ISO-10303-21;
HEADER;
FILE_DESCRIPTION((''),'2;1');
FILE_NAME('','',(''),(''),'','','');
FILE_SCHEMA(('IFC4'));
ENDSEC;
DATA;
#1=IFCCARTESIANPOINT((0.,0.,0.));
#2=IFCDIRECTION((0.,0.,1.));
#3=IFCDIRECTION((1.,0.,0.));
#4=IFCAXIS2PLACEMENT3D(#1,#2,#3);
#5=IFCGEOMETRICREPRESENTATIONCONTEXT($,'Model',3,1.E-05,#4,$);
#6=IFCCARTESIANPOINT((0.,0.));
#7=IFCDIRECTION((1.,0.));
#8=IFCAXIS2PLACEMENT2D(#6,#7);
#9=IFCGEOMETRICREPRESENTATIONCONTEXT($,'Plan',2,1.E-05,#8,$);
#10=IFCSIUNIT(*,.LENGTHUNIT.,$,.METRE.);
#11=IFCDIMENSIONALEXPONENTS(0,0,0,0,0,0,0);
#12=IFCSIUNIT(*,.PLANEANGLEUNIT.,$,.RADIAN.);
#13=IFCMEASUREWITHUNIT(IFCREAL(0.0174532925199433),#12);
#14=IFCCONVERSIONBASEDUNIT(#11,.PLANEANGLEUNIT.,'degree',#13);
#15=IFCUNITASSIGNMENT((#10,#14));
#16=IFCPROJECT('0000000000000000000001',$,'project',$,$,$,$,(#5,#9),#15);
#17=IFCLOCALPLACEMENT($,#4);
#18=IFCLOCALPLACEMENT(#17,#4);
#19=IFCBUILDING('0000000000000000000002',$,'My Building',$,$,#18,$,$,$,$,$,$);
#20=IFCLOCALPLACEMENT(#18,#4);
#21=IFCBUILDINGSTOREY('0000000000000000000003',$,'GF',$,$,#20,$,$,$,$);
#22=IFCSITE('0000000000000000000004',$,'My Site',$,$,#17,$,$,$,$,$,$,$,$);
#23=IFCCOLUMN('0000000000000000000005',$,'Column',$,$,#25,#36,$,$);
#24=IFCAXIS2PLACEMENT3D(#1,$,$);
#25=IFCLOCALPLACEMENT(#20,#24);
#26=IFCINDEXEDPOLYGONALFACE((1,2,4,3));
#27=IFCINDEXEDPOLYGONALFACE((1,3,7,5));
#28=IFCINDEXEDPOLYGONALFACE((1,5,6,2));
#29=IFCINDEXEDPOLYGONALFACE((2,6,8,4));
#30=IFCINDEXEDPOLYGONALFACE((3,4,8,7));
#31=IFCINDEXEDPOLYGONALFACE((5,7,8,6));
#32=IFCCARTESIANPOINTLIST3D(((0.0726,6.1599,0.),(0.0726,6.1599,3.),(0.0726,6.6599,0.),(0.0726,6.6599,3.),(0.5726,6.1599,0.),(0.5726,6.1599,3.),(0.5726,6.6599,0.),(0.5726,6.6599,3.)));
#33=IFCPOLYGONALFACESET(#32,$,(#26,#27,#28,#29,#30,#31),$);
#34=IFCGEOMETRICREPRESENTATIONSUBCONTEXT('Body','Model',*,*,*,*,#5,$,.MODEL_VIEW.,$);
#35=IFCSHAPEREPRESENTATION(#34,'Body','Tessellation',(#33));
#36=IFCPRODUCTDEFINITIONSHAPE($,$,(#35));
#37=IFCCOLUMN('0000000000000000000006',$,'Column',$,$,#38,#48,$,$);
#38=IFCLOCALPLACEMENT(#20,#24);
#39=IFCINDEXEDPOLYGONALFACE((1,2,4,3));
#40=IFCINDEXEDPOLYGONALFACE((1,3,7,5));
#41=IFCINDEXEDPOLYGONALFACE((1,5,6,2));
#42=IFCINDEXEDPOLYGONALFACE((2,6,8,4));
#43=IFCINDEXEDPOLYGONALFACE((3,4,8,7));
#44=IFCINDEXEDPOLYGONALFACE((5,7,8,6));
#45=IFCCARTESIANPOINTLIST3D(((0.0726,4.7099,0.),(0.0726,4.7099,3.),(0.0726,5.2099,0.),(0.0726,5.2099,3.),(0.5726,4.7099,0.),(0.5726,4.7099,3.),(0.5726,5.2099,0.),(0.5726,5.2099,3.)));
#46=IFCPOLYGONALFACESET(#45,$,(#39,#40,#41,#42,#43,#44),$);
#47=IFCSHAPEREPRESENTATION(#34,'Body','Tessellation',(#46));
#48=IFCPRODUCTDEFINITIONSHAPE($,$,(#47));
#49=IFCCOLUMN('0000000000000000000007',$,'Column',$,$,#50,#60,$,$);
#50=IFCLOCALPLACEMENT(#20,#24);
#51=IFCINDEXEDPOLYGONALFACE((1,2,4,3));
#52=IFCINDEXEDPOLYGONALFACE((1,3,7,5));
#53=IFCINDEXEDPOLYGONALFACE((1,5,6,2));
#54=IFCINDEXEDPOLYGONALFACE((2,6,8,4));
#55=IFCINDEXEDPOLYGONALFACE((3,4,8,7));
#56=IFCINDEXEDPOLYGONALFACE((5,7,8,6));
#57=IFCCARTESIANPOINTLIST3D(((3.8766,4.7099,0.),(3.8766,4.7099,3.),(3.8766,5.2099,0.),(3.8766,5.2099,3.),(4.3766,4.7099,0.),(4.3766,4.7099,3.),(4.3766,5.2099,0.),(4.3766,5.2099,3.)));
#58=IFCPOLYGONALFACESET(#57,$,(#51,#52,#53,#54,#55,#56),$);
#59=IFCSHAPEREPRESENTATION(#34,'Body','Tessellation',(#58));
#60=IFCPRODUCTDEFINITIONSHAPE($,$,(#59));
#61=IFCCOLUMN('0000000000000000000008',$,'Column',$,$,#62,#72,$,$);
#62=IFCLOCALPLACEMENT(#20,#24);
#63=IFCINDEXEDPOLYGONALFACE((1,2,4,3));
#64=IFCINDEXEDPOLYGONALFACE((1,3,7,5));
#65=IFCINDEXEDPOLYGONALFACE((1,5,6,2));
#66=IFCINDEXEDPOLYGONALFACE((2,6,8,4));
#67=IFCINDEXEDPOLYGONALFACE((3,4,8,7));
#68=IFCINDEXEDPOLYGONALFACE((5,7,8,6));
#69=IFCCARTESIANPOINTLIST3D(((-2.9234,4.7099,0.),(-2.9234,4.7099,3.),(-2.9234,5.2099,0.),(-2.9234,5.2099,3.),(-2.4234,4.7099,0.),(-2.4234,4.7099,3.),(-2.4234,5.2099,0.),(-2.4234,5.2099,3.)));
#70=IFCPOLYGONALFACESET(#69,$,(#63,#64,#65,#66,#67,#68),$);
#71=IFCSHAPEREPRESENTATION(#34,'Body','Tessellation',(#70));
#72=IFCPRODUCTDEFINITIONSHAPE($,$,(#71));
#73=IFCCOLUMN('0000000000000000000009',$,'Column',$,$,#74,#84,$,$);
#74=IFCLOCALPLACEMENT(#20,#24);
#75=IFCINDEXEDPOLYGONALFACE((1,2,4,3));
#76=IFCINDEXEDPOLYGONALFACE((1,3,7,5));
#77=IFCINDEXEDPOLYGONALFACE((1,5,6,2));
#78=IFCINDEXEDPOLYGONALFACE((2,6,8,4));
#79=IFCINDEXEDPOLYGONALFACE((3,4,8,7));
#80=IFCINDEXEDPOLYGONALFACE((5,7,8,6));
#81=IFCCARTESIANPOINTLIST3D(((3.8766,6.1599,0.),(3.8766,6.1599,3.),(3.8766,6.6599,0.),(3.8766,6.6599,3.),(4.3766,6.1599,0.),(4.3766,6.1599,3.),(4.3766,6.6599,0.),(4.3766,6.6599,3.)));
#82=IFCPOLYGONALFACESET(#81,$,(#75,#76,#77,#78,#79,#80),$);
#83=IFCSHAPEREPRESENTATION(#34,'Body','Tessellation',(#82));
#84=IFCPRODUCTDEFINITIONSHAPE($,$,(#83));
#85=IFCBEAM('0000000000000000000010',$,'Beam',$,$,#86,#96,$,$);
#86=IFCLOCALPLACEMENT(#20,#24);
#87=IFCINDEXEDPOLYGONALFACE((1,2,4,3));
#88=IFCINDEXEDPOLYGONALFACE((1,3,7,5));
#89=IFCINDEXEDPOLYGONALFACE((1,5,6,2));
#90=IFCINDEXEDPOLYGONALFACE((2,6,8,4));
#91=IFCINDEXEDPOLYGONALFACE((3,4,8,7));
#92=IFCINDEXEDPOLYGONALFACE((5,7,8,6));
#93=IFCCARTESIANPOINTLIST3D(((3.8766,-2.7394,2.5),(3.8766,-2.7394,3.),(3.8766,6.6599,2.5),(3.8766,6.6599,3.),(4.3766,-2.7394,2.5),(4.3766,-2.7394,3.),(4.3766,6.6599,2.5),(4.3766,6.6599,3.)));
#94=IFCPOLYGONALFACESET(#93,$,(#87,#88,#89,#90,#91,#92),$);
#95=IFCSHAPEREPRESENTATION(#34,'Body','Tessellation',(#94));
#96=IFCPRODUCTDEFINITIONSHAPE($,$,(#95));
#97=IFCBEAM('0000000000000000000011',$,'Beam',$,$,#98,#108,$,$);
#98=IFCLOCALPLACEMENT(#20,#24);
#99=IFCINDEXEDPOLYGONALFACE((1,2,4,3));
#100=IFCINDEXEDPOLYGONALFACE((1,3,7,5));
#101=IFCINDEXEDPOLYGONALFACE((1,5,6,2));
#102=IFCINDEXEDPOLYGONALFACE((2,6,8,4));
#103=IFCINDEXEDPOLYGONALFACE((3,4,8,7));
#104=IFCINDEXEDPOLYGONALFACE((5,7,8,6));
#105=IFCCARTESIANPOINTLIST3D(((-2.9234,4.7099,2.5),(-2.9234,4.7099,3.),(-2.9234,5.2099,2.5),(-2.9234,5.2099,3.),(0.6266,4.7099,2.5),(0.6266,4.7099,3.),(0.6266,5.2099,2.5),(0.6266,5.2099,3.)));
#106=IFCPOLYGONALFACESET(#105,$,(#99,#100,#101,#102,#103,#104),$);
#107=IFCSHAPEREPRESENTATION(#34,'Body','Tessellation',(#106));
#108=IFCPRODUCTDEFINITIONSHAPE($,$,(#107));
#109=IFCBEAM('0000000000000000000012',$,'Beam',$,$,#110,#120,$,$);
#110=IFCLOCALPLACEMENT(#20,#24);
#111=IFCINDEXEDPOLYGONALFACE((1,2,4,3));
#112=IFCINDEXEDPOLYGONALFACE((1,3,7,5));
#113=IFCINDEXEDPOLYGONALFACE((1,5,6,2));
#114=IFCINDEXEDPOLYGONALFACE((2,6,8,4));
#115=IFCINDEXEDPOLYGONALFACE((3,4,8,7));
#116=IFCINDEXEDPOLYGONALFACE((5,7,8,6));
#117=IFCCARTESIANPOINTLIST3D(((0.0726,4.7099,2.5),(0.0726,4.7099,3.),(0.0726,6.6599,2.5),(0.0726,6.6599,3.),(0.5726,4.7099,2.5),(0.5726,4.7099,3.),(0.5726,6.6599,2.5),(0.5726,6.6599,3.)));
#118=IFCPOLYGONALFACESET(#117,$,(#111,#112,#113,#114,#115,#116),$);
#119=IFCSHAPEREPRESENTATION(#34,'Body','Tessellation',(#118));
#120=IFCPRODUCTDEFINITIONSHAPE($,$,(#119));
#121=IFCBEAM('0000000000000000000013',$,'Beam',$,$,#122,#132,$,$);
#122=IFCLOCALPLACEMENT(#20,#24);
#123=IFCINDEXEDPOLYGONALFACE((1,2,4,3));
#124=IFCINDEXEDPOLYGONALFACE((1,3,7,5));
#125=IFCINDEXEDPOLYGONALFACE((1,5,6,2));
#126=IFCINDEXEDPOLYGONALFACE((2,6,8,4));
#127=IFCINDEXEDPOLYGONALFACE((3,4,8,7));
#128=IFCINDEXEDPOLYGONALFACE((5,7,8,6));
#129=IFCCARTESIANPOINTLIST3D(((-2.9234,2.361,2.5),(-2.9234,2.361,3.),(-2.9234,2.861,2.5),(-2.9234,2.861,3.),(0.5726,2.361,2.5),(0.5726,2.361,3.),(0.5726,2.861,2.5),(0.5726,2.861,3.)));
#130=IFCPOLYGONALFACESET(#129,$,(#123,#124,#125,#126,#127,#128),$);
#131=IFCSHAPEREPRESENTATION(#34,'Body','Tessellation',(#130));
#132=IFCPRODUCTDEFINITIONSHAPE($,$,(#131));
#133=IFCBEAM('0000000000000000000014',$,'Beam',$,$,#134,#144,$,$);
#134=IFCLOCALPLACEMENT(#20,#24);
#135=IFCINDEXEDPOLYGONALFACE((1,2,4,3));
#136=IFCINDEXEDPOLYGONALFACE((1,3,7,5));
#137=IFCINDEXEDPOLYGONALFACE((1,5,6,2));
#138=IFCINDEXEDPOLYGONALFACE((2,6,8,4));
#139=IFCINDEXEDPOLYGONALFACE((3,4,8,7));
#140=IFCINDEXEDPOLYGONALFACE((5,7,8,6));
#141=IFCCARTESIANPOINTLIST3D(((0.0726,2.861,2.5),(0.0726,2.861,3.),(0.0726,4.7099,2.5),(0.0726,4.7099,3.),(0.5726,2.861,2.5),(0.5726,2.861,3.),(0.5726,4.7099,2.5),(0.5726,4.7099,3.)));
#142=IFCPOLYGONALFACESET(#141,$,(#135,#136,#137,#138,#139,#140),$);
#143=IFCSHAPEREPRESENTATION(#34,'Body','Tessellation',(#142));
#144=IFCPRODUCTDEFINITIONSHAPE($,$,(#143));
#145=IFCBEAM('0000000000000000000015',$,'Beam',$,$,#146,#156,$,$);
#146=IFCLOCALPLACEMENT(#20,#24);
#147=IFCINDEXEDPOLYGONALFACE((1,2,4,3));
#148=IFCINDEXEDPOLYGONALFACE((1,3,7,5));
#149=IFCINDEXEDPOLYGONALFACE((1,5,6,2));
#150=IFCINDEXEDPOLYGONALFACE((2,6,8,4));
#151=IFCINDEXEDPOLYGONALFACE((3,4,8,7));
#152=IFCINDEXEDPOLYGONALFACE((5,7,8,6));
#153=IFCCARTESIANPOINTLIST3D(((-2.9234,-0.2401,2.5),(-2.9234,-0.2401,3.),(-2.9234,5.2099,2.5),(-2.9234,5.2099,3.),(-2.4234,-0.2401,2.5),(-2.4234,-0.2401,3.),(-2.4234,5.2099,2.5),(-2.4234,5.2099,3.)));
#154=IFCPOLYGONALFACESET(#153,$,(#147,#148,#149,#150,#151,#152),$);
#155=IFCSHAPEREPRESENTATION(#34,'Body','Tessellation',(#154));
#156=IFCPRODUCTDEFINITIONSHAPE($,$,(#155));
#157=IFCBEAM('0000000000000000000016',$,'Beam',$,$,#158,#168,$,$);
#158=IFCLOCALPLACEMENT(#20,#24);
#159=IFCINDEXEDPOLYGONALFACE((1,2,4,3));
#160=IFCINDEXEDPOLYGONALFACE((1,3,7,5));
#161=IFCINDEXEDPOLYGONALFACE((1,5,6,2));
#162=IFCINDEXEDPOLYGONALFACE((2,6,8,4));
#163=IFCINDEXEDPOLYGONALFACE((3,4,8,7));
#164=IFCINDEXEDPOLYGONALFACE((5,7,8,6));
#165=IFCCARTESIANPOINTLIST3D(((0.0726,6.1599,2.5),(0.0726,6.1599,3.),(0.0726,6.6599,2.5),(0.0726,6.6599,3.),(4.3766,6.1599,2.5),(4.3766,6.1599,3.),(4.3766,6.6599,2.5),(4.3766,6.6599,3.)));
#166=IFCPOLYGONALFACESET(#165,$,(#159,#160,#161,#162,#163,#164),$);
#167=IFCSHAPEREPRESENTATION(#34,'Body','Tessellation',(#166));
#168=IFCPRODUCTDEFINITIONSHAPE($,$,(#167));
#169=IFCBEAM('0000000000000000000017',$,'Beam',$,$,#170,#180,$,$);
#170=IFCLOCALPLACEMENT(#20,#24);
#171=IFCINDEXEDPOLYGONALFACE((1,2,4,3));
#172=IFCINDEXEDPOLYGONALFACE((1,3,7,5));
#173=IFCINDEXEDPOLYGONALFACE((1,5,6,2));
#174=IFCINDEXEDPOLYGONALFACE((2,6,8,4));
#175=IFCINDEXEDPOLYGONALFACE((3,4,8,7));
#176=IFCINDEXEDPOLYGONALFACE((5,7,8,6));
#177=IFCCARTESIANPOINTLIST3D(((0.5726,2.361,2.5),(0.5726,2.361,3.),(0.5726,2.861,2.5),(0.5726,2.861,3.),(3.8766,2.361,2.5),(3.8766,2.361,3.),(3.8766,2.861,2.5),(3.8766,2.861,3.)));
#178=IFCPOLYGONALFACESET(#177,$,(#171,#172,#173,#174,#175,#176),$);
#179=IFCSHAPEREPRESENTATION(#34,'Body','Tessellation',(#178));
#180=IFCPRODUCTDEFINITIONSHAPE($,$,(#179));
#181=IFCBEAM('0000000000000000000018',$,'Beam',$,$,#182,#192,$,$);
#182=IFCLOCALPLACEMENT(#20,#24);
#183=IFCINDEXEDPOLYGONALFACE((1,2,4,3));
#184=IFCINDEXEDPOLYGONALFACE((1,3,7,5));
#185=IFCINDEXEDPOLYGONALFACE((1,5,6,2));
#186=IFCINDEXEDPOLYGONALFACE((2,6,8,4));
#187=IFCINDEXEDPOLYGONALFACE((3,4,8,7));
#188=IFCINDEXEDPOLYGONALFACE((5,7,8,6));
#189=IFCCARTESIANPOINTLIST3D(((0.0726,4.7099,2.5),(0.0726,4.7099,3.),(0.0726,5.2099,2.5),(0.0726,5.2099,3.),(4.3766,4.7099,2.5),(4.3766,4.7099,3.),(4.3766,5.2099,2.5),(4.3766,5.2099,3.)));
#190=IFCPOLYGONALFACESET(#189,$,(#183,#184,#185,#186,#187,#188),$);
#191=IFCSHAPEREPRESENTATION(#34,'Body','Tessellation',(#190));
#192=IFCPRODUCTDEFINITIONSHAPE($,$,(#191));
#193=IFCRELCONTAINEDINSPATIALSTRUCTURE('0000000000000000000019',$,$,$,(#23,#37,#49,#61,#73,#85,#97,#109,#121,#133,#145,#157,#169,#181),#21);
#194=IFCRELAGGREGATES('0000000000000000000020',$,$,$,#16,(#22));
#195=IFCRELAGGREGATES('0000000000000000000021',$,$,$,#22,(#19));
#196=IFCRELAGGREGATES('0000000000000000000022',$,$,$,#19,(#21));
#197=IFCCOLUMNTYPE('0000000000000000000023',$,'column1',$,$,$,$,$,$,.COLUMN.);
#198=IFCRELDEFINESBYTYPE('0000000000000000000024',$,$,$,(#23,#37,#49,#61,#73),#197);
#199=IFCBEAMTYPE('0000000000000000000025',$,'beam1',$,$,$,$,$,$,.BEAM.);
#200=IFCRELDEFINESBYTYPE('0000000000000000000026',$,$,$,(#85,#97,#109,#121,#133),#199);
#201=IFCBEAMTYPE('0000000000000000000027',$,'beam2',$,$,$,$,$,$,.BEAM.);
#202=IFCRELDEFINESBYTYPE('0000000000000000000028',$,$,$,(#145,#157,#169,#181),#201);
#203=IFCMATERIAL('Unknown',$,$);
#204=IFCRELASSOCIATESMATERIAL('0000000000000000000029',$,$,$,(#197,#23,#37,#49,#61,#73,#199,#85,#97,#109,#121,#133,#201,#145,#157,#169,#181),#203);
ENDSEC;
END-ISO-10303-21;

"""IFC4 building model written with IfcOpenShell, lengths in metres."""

from ifc_helpers import new_model, entity, si_unit, converted_unit, frame, origin_with_axes, origin_2d_with_axis, place, context, subcontext, project, spatial, rectangle, extrude, material, material_profile, profile_set, profile_usage, type_object, element, save


model = new_model("IFC4")

# Units and contexts
model_context = context("Model", 3, precision=1e-05, world=origin_with_axes())
plan_context = context("Plan", 2, precision=1e-05, world=origin_2d_with_axis())
body_context_1 = subcontext(model_context, "Body", "Model", "MODEL_VIEW")
ifc_project = project(units=[si_unit("LENGTHUNIT", "METRE"), converted_unit("PLANEANGLEUNIT", "degree", entity("IfcReal", 0.0174532925199433), si_unit("PLANEANGLEUNIT", "RADIAN"), dimensions=[0, 0, 0, 0, 0, 0, 0])], contexts=[model_context, plan_context])

# Site, building, storey
site_placement = place(None, origin_with_axes())
site = spatial("IfcSite", under=ifc_project, at=site_placement, Name="My Site")
building_placement = place(site_placement, origin_with_axes())
building = spatial("IfcBuilding", under=site, at=building_placement, Name="My Building")
storey_placement = place(building_placement, origin_with_axes())
storey = spatial("IfcBuildingStorey", under=building, at=storey_placement, Name="GF")

# Columns
ifc_material = material(Name="Unknown")
ifc_material_profile_1 = material_profile(ifc_material, rectangle(XDim=0.5, YDim=0.5))
ifc_profile_set_1 = profile_set([ifc_material_profile_1])
ifc_profile_usage_1 = profile_usage(ifc_profile_set_1, cardinal=5)
column_type = type_object("IfcColumnType", Name="column1", PredefinedType="COLUMN", material=ifc_profile_set_1)
column_1_placement = place(storey_placement, frame((0.3226, 6.4099, 0.0), z_axis=(0.0, 0.0, 1.0), x_axis=(1.0, 0.0, 0.0)))
element("IfcColumn", 1, at=column_1_placement, inside=storey, type_object=column_type, material=ifc_profile_usage_1, Name="Column", context=body_context_1, shape_type="SweptSolid", body=[
    extrude(rectangle(XDim=0.5, YDim=0.5), origin_with_axes(), (0.0, 0.0, 1.0), 3.0),
])
ifc_profile_usage_2 = profile_usage(ifc_profile_set_1, cardinal=5)
column_2_placement = place(storey_placement, frame((0.3226, 4.9599, 0.0), z_axis=(0.0, 0.0, 1.0), x_axis=(1.0, 0.0, 0.0)))
element("IfcColumn", 2, at=column_2_placement, inside=storey, type_object=column_type, material=ifc_profile_usage_2, Name="Column", context=body_context_1, shape_type="SweptSolid", body=[
    extrude(rectangle(XDim=0.5, YDim=0.5), origin_with_axes(), (0.0, 0.0, 1.0), 3.0),
])
ifc_profile_usage_3 = profile_usage(ifc_profile_set_1, cardinal=5)
column_3_placement = place(storey_placement, frame((4.1266, 4.9599, 0.0), z_axis=(0.0, 0.0, 1.0), x_axis=(1.0, 0.0, 0.0)))
element("IfcColumn", 3, at=column_3_placement, inside=storey, type_object=column_type, material=ifc_profile_usage_3, Name="Column", context=body_context_1, shape_type="SweptSolid", body=[
    extrude(rectangle(XDim=0.5, YDim=0.5), origin_with_axes(), (0.0, 0.0, 1.0), 3.0),
])
ifc_profile_usage_4 = profile_usage(ifc_profile_set_1, cardinal=5)
column_4_placement = place(storey_placement, frame((-2.6734, 4.9599, 0.0), z_axis=(0.0, 0.0, 1.0), x_axis=(1.0, 0.0, 0.0)))
element("IfcColumn", 4, at=column_4_placement, inside=storey, type_object=column_type, material=ifc_profile_usage_4, Name="Column", context=body_context_1, shape_type="SweptSolid", body=[
    extrude(rectangle(XDim=0.5, YDim=0.5), origin_with_axes(), (0.0, 0.0, 1.0), 3.0),
])
ifc_profile_usage_5 = profile_usage(ifc_profile_set_1, cardinal=5)
column_5_placement = place(storey_placement, frame((4.1266, 6.4099, 0.0), z_axis=(0.0, 0.0, 1.0), x_axis=(1.0, 0.0, 0.0)))
element("IfcColumn", 5, at=column_5_placement, inside=storey, type_object=column_type, material=ifc_profile_usage_5, Name="Column", context=body_context_1, shape_type="SweptSolid", body=[
    extrude(rectangle(XDim=0.5, YDim=0.5), origin_with_axes(), (0.0, 0.0, 1.0), 3.0),
])

# Beams
ifc_material_profile_2 = material_profile(ifc_material, rectangle(XDim=0.5, YDim=0.5))
ifc_profile_set_2 = profile_set([ifc_material_profile_2])
ifc_profile_usage_6 = profile_usage(ifc_profile_set_2, cardinal=7)
beam_type_1 = type_object("IfcBeamType", Name="beam1", PredefinedType="BEAM", material=ifc_profile_set_2)
beam_1_placement = place(storey_placement, frame((4.3766, 6.6599, 3.0), z_axis=(0.0, -1.0, 0.0), x_axis=(1.0, 0.0, 0.0)))
element("IfcBeam", 6, at=beam_1_placement, inside=storey, type_object=beam_type_1, material=ifc_profile_usage_6, Name="Beam", context=body_context_1, shape_type="SweptSolid", body=[
    extrude(rectangle(XDim=0.5, YDim=0.5), frame((-0.25, -0.25, 0.0), z_axis=(0.0, 0.0, 1.0), x_axis=(1.0, 0.0, 0.0)), (0.0, 0.0, 1.0), 9.3993),
])
ifc_profile_usage_7 = profile_usage(ifc_profile_set_2, cardinal=7)
beam_2_placement = place(storey_placement, frame((-2.9234, 5.2099, 3.0), z_axis=(1.0, -0.000001, 0.000001), x_axis=(0.000001, 1.0, 0.0)))
element("IfcBeam", 7, at=beam_2_placement, inside=storey, type_object=beam_type_1, material=ifc_profile_usage_7, Name="Beam", context=body_context_1, shape_type="SweptSolid", body=[
    extrude(rectangle(XDim=0.5, YDim=0.5), frame((-0.25, -0.25, 0.0), z_axis=(0.0, 0.0, 1.0), x_axis=(1.0, 0.0, 0.0)), (0.0, 0.0, 1.0), 3.55),
])
ifc_profile_usage_8 = profile_usage(ifc_profile_set_2, cardinal=7)
beam_3_placement = place(storey_placement, frame((0.0726, 4.7099, 3.0), z_axis=(0.0, 1.0, 0.0), x_axis=(-1.0, 0.0, 0.0)))
element("IfcBeam", 8, at=beam_3_placement, inside=storey, type_object=beam_type_1, material=ifc_profile_usage_8, Name="Beam", context=body_context_1, shape_type="SweptSolid", body=[
    extrude(rectangle(XDim=0.5, YDim=0.5), frame((-0.25, -0.25, 0.0), z_axis=(0.0, 0.0, 1.0), x_axis=(1.0, 0.0, 0.0)), (0.0, 0.0, 1.0), 1.95),
])
ifc_profile_usage_9 = profile_usage(ifc_profile_set_2, cardinal=7)
beam_4_placement = place(storey_placement, frame((-2.9234, 2.861, 3.0), z_axis=(1.0, -0.000001, 0.000001), x_axis=(0.000001, 1.0, 0.0)))
element("IfcBeam", 9, at=beam_4_placement, inside=storey, type_object=beam_type_1, material=ifc_profile_usage_9, Name="Beam", context=body_context_1, shape_type="SweptSolid", body=[
    extrude(rectangle(XDim=0.5, YDim=0.5), frame((-0.25, -0.25, 0.0), z_axis=(0.0, 0.0, 1.0), x_axis=(1.0, 0.0, 0.0)), (0.0, 0.0, 1.0), 3.496),
])
ifc_profile_usage_10 = profile_usage(ifc_profile_set_2, cardinal=7)
beam_5_placement = place(storey_placement, frame((0.5726, 4.7099, 3.0), z_axis=(0.0, -1.0, 0.0), x_axis=(1.0, 0.0, 0.0)))
element("IfcBeam", 10, at=beam_5_placement, inside=storey, type_object=beam_type_1, material=ifc_profile_usage_10, Name="Beam", context=body_context_1, shape_type="SweptSolid", body=[
    extrude(rectangle(XDim=0.5, YDim=0.5), frame((-0.25, -0.25, 0.0), z_axis=(0.0, 0.0, 1.0), x_axis=(1.0, 0.0, 0.0)), (0.0, 0.0, 1.0), 1.8489),
])
ifc_material_profile_3 = material_profile(ifc_material, rectangle(XDim=0.5, YDim=0.5))
ifc_profile_set_3 = profile_set([ifc_material_profile_3])
ifc_profile_usage_11 = profile_usage(ifc_profile_set_3, cardinal=7)
beam_type_2 = type_object("IfcBeamType", Name="beam2", PredefinedType="BEAM", material=ifc_profile_set_3)
beam_6_placement = place(storey_placement, frame((-2.4234, 5.2099, 3.0), z_axis=(0.0, -1.0, 0.000001), x_axis=(1.0, 0.0, 0.0)))
element("IfcBeam", 11, at=beam_6_placement, inside=storey, type_object=beam_type_2, material=ifc_profile_usage_11, Name="Beam", context=body_context_1, shape_type="SweptSolid", body=[
    extrude(rectangle(XDim=0.5, YDim=0.5), frame((-0.25, -0.25, 0.0), z_axis=(0.0, 0.0, 1.0), x_axis=(1.0, 0.0, 0.0)), (0.0, 0.0, 1.0), 5.45),
])
ifc_profile_usage_12 = profile_usage(ifc_profile_set_3, cardinal=7)
beam_7_placement = place(storey_placement, frame((0.0726, 6.6599, 3.0), z_axis=(1.0, 0.0, 0.0), x_axis=(0.0, 1.0, 0.0)))
element("IfcBeam", 12, at=beam_7_placement, inside=storey, type_object=beam_type_2, material=ifc_profile_usage_12, Name="Beam", context=body_context_1, shape_type="SweptSolid", body=[
    extrude(rectangle(XDim=0.5, YDim=0.5), frame((-0.25, -0.25, 0.0), z_axis=(0.0, 0.0, 1.0), x_axis=(1.0, 0.0, 0.0)), (0.0, 0.0, 1.0), 4.304),
])
ifc_profile_usage_13 = profile_usage(ifc_profile_set_3, cardinal=7)
beam_8_placement = place(storey_placement, frame((0.5726, 2.861, 3.0), z_axis=(1.0, 0.0, 0.0), x_axis=(0.0, 1.0, 0.0)))
element("IfcBeam", 13, at=beam_8_placement, inside=storey, type_object=beam_type_2, material=ifc_profile_usage_13, Name="Beam", context=body_context_1, shape_type="SweptSolid", body=[
    extrude(rectangle(XDim=0.5, YDim=0.5), frame((-0.25, -0.25, 0.0), z_axis=(0.0, 0.0, 1.0), x_axis=(1.0, 0.0, 0.0)), (0.0, 0.0, 1.0), 3.304),
])
ifc_profile_usage_14 = profile_usage(ifc_profile_set_3, cardinal=7)
beam_9_placement = place(storey_placement, frame((0.0726, 5.2099, 3.0), z_axis=(1.0, 0.0, 0.0), x_axis=(0.0, 1.0, 0.0)))
element("IfcBeam", 14, at=beam_9_placement, inside=storey, type_object=beam_type_2, material=ifc_profile_usage_14, Name="Beam", context=body_context_1, shape_type="SweptSolid", body=[
    extrude(rectangle(XDim=0.5, YDim=0.5), frame((-0.25, -0.25, 0.0), z_axis=(0.0, 0.0, 1.0), x_axis=(1.0, 0.0, 0.0)), (0.0, 0.0, 1.0), 4.3041),
])

save(model, "model.ifc")
